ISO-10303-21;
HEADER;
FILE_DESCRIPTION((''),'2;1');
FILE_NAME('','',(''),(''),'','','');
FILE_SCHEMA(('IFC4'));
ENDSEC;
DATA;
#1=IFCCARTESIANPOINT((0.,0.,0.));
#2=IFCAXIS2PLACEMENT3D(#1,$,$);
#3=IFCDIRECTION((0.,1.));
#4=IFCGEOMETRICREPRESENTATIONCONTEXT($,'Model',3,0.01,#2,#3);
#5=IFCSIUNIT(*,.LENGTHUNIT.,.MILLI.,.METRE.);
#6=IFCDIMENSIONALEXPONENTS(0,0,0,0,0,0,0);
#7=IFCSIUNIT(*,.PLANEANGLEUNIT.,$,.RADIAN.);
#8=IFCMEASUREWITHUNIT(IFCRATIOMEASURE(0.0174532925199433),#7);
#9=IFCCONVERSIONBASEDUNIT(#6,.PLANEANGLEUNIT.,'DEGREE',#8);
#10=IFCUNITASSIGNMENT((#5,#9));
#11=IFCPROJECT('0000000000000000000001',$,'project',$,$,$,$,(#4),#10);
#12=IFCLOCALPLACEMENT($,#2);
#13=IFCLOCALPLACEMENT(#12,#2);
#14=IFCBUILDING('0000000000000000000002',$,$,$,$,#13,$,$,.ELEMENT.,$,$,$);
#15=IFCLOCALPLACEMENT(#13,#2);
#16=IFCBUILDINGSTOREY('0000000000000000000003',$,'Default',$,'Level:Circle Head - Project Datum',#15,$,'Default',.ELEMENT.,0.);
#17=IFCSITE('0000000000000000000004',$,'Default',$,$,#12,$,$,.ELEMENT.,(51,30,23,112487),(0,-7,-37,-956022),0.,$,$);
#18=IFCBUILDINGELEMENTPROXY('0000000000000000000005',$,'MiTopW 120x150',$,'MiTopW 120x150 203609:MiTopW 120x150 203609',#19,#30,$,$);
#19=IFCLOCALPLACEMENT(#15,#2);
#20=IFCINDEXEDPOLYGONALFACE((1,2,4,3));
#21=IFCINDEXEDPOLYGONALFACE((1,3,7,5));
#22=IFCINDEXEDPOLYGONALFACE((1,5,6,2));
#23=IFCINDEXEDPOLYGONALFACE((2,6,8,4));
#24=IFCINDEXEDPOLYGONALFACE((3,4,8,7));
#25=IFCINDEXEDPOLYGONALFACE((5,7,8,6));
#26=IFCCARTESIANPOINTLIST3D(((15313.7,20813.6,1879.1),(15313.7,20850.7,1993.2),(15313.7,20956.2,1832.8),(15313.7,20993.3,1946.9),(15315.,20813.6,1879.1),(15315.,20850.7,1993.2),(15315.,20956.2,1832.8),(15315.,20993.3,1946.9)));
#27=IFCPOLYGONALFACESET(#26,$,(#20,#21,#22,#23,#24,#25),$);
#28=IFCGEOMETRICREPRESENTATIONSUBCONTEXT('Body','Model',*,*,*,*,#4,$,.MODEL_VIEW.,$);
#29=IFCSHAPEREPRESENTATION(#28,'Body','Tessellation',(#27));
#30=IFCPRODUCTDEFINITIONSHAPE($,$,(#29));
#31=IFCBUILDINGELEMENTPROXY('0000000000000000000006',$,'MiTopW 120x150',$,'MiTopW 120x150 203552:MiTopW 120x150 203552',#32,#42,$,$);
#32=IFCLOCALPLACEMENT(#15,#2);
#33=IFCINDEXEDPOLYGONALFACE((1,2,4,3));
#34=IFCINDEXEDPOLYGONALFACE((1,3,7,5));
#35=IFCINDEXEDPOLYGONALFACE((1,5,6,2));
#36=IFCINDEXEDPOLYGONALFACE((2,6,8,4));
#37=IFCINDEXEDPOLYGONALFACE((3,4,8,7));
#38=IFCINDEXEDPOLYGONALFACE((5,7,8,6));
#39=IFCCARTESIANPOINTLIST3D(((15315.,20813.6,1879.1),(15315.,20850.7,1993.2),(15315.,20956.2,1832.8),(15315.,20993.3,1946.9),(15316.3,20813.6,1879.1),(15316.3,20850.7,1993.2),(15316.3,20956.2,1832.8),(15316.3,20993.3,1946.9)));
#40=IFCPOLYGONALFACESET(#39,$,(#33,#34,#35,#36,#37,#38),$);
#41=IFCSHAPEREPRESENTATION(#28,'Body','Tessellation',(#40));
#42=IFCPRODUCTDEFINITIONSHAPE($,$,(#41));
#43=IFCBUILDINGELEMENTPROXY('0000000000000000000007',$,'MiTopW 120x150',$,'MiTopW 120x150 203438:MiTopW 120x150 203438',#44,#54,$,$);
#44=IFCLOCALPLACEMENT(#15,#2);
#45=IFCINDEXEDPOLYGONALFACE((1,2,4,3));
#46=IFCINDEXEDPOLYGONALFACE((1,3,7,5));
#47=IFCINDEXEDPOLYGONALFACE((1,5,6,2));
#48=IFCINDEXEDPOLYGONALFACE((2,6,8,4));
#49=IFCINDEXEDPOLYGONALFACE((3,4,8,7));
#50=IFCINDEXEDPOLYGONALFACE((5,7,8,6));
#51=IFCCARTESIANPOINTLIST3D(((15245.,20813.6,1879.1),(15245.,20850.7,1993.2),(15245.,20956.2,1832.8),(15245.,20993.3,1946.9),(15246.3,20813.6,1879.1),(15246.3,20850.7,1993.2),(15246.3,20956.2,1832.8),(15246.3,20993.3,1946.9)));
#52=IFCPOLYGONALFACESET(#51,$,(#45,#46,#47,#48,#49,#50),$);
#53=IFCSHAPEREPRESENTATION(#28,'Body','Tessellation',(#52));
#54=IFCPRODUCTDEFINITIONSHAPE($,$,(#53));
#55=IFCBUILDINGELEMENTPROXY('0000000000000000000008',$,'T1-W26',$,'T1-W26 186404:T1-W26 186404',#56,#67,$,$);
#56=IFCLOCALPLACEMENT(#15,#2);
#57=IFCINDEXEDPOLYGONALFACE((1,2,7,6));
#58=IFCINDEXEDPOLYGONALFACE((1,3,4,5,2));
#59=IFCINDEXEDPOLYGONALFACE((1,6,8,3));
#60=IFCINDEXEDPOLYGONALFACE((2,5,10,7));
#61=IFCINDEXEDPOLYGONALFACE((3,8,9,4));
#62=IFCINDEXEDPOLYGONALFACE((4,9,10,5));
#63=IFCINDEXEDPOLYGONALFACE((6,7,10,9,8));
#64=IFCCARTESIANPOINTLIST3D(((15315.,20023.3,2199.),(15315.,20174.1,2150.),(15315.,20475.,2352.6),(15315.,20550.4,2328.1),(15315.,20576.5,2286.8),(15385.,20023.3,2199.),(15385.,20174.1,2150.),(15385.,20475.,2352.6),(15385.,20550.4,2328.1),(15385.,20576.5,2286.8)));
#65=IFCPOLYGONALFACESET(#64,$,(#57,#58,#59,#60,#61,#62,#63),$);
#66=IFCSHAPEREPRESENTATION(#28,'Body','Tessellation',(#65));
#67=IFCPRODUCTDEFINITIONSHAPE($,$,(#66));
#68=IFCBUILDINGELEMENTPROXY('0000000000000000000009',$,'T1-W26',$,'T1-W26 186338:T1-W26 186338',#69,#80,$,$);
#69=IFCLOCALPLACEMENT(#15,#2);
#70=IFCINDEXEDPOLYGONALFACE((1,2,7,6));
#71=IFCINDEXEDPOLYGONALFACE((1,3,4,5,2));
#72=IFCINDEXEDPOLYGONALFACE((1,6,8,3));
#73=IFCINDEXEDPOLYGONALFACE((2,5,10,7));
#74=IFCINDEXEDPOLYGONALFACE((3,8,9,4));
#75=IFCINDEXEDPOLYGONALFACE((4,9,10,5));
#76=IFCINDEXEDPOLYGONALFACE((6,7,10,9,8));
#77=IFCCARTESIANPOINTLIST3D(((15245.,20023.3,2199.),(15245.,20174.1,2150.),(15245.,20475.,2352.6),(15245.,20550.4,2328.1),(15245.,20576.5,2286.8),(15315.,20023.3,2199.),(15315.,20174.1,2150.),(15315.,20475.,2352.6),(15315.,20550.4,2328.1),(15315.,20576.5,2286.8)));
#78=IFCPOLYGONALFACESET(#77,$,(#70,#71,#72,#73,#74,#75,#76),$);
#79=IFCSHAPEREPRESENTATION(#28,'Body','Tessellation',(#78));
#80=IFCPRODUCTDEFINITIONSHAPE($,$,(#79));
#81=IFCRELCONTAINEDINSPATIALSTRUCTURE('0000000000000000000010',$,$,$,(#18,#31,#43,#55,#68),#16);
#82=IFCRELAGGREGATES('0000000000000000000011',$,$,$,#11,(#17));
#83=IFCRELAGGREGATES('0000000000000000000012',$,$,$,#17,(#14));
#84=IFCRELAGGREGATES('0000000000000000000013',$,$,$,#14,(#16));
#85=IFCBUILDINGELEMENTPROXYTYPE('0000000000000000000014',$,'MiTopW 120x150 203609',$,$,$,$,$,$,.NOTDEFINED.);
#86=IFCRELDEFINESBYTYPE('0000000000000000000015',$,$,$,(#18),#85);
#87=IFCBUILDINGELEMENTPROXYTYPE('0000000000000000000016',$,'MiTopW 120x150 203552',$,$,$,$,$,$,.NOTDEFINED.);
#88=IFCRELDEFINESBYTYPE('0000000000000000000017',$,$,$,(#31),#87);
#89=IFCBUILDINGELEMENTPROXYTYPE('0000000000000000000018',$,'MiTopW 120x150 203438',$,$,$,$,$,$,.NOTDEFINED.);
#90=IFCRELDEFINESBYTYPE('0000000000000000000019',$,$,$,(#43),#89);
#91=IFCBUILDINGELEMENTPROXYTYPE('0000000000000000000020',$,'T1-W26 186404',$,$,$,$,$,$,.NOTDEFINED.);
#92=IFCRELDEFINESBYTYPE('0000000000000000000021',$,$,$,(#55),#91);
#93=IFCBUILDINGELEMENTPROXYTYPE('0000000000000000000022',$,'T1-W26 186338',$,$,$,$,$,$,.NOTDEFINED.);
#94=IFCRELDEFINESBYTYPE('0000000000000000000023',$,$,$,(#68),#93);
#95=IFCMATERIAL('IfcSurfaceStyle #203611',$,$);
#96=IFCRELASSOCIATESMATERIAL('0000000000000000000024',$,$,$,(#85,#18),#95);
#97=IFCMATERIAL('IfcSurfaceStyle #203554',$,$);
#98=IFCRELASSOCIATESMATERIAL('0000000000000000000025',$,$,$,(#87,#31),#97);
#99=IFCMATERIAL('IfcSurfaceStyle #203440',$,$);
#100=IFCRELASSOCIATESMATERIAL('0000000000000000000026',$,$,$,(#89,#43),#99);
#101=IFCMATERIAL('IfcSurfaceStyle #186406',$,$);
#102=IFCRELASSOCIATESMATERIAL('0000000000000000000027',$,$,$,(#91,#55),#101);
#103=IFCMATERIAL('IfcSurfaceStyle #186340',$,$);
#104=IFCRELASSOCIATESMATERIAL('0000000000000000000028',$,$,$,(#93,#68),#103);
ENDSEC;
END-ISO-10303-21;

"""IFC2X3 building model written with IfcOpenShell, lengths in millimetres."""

from ifc_helpers import new_model, entity, si_unit, converted_unit, direction, frame, origin, place, context, subcontext, project, spatial, polyline, outline, extrude, source, transform, mapped, material, type_object, type_shapes, element, save


model = new_model("IFC2X3")

# Units and contexts
model_context = context("Model", 3, precision=0.01, world=origin(), true_north=direction((0.0, 1.0)))
body_context = subcontext(model_context, "Body", "Model", "MODEL_VIEW")
ifc_project = project(units=[si_unit("LENGTHUNIT", "METRE", prefix="MILLI"), converted_unit("PLANEANGLEUNIT", "DEGREE", entity("IfcRatioMeasure", 0.0174532925199433), si_unit("PLANEANGLEUNIT", "RADIAN"), dimensions=[0, 0, 0, 0, 0, 0, 0])], contexts=[model_context])

# Site, building, storey
site_placement = place(None, origin())
site = spatial("IfcSite", under=ifc_project, at=site_placement, Name="Default", CompositionType="ELEMENT", RefLatitude=(51, 30, 23, 112487), RefLongitude=(0, -7, -37, -956022), RefElevation=0.0)
building_placement = place(site_placement, origin())
building = spatial("IfcBuilding", under=site, at=building_placement, CompositionType="ELEMENT")
storey_placement = place(building_placement, origin())
storey = spatial("IfcBuildingStorey", under=building, at=storey_placement, Name="Default", ObjectType="Level:Circle Head - Project Datum", LongName="Default", CompositionType="ELEMENT", Elevation=0.0)

# Building element proxies
ifc_material_1 = material(Name="IfcSurfaceStyle #203611")
building_element_proxy_type_1 = type_object("IfcBuildingElementProxyType", Name="MiTopW 120x150 203609", PredefinedType="NOTDEFINED", material=ifc_material_1)
shared_shape_1 = source(origin(), body_context, "Body", "SweptSolid", [
    extrude(outline(polyline([(-75.0, -60.0), (75.0, -60.0), (75.0, 60.0), (-75.0, 60.0), (-75.0, -60.0)])), frame((75.0, 60.0, 0.0), z_axis=(0.0, 0.0, 1.0), x_axis=(-1.0, 0.0, 0.0)), (0.0, 0.0, 1.0), 1.3),
])
type_shapes(building_element_proxy_type_1, [shared_shape_1])
proxy_1_placement = place(building_placement, frame((15315.0, 20956.2, 1832.8), z_axis=(-1.0, 0.0, 0.0), x_axis=(0.0, -0.951057, 0.309017)))
element("IfcBuildingElementProxy", 1, at=proxy_1_placement, inside=storey, type_object=building_element_proxy_type_1, material=ifc_material_1, Name="MiTopW 120x150", ObjectType="MiTopW 120x150 203609:MiTopW 120x150 203609", context=body_context, shape_type="MappedRepresentation", body=[
    mapped(shared_shape_1, transform((0.0, 0.0, 0.0), scale=1.0)),
])
ifc_material_2 = material(Name="IfcSurfaceStyle #203554")
building_element_proxy_type_2 = type_object("IfcBuildingElementProxyType", Name="MiTopW 120x150 203552", PredefinedType="NOTDEFINED", material=ifc_material_2)
shared_shape_2 = source(origin(), body_context, "Body", "SweptSolid", [
    extrude(outline(polyline([(-75.0, -60.0), (75.0, -60.0), (75.0, 60.0), (-75.0, 60.0), (-75.0, -60.0)])), frame((75.0, 60.0, 0.0), z_axis=(0.0, 0.0, 1.0), x_axis=(-1.0, 0.0, 0.0)), (0.0, 0.0, 1.0), 1.3),
])
type_shapes(building_element_proxy_type_2, [shared_shape_2])
proxy_2_placement = place(building_placement, frame((15316.3, 20956.2, 1832.8), z_axis=(-1.0, 0.0, 0.0), x_axis=(0.0, -0.951057, 0.309017)))
element("IfcBuildingElementProxy", 2, at=proxy_2_placement, inside=storey, type_object=building_element_proxy_type_2, material=ifc_material_2, Name="MiTopW 120x150", ObjectType="MiTopW 120x150 203552:MiTopW 120x150 203552", context=body_context, shape_type="MappedRepresentation", body=[
    mapped(shared_shape_2, transform((0.0, 0.0, 0.0), scale=1.0)),
])
ifc_material_3 = material(Name="IfcSurfaceStyle #203440")
building_element_proxy_type_3 = type_object("IfcBuildingElementProxyType", Name="MiTopW 120x150 203438", PredefinedType="NOTDEFINED", material=ifc_material_3)
shared_shape_3 = source(origin(), body_context, "Body", "SweptSolid", [
    extrude(outline(polyline([(-75.0, -60.0), (75.0, -60.0), (75.0, 60.0), (-75.0, 60.0), (-75.0, -60.0)])), frame((75.0, 60.0, 0.0), z_axis=(0.0, 0.0, 1.0), x_axis=(-1.0, 0.0, 0.0)), (0.0, 0.0, 1.0), 1.3),
])
type_shapes(building_element_proxy_type_3, [shared_shape_3])
proxy_3_placement = place(building_placement, frame((15246.3, 20956.2, 1832.8), z_axis=(-1.0, 0.0, 0.0), x_axis=(0.0, -0.951057, 0.309017)))
element("IfcBuildingElementProxy", 3, at=proxy_3_placement, inside=storey, type_object=building_element_proxy_type_3, material=ifc_material_3, Name="MiTopW 120x150", ObjectType="MiTopW 120x150 203438:MiTopW 120x150 203438", context=body_context, shape_type="MappedRepresentation", body=[
    mapped(shared_shape_3, transform((0.0, 0.0, 0.0), scale=1.0)),
])
ifc_material_4 = material(Name="IfcSurfaceStyle #186406")
building_element_proxy_type_4 = type_object("IfcBuildingElementProxyType", Name="T1-W26 186404", PredefinedType="NOTDEFINED", material=ifc_material_4)
shared_shape_4 = source(origin(), body_context, "Body", "SweptSolid", [
    extrude(outline(polyline([(-339.4, -47.5), (137.7, -47.5), (201.3, 0.0), (212.7, 47.5), (-212.3, 47.5), (-339.4, -47.5)])), frame((212.7, 47.5, 0.0), z_axis=(0.0, 0.0, 1.0), x_axis=(-1.0, 0.0, 0.0)), (0.0, 0.0, 1.0), 70.0),
])
type_shapes(building_element_proxy_type_4, [shared_shape_4])
proxy_4_placement = place(building_placement, frame((15385.0, 20576.5, 2286.8), z_axis=(-1.0, 0.0, 0.0), x_axis=(0.0, -0.946744, -0.321988)))
element("IfcBuildingElementProxy", 4, at=proxy_4_placement, inside=storey, type_object=building_element_proxy_type_4, material=ifc_material_4, Name="T1-W26", ObjectType="T1-W26 186404:T1-W26 186404", context=body_context, shape_type="MappedRepresentation", body=[
    mapped(shared_shape_4, transform((0.0, 0.0, 0.0), scale=1.0)),
])
ifc_material_5 = material(Name="IfcSurfaceStyle #186340")
building_element_proxy_type_5 = type_object("IfcBuildingElementProxyType", Name="T1-W26 186338", PredefinedType="NOTDEFINED", material=ifc_material_5)
shared_shape_5 = source(origin(), body_context, "Body", "SweptSolid", [
    extrude(outline(polyline([(-339.4, -47.5), (137.7, -47.5), (201.3, 0.0), (212.7, 47.5), (-212.3, 47.5), (-339.4, -47.5)])), frame((212.7, 47.5, 0.0), z_axis=(0.0, 0.0, 1.0), x_axis=(-1.0, 0.0, 0.0)), (0.0, 0.0, 1.0), 70.0),
])
type_shapes(building_element_proxy_type_5, [shared_shape_5])
proxy_5_placement = place(building_placement, frame((15315.0, 20576.5, 2286.8), z_axis=(-1.0, 0.0, 0.0), x_axis=(0.0, -0.946744, -0.321988)))
element("IfcBuildingElementProxy", 5, at=proxy_5_placement, inside=storey, type_object=building_element_proxy_type_5, material=ifc_material_5, Name="T1-W26", ObjectType="T1-W26 186338:T1-W26 186338", context=body_context, shape_type="MappedRepresentation", body=[
    mapped(shared_shape_5, transform((0.0, 0.0, 0.0), scale=1.0)),
])

save(model, "model.ifc")
